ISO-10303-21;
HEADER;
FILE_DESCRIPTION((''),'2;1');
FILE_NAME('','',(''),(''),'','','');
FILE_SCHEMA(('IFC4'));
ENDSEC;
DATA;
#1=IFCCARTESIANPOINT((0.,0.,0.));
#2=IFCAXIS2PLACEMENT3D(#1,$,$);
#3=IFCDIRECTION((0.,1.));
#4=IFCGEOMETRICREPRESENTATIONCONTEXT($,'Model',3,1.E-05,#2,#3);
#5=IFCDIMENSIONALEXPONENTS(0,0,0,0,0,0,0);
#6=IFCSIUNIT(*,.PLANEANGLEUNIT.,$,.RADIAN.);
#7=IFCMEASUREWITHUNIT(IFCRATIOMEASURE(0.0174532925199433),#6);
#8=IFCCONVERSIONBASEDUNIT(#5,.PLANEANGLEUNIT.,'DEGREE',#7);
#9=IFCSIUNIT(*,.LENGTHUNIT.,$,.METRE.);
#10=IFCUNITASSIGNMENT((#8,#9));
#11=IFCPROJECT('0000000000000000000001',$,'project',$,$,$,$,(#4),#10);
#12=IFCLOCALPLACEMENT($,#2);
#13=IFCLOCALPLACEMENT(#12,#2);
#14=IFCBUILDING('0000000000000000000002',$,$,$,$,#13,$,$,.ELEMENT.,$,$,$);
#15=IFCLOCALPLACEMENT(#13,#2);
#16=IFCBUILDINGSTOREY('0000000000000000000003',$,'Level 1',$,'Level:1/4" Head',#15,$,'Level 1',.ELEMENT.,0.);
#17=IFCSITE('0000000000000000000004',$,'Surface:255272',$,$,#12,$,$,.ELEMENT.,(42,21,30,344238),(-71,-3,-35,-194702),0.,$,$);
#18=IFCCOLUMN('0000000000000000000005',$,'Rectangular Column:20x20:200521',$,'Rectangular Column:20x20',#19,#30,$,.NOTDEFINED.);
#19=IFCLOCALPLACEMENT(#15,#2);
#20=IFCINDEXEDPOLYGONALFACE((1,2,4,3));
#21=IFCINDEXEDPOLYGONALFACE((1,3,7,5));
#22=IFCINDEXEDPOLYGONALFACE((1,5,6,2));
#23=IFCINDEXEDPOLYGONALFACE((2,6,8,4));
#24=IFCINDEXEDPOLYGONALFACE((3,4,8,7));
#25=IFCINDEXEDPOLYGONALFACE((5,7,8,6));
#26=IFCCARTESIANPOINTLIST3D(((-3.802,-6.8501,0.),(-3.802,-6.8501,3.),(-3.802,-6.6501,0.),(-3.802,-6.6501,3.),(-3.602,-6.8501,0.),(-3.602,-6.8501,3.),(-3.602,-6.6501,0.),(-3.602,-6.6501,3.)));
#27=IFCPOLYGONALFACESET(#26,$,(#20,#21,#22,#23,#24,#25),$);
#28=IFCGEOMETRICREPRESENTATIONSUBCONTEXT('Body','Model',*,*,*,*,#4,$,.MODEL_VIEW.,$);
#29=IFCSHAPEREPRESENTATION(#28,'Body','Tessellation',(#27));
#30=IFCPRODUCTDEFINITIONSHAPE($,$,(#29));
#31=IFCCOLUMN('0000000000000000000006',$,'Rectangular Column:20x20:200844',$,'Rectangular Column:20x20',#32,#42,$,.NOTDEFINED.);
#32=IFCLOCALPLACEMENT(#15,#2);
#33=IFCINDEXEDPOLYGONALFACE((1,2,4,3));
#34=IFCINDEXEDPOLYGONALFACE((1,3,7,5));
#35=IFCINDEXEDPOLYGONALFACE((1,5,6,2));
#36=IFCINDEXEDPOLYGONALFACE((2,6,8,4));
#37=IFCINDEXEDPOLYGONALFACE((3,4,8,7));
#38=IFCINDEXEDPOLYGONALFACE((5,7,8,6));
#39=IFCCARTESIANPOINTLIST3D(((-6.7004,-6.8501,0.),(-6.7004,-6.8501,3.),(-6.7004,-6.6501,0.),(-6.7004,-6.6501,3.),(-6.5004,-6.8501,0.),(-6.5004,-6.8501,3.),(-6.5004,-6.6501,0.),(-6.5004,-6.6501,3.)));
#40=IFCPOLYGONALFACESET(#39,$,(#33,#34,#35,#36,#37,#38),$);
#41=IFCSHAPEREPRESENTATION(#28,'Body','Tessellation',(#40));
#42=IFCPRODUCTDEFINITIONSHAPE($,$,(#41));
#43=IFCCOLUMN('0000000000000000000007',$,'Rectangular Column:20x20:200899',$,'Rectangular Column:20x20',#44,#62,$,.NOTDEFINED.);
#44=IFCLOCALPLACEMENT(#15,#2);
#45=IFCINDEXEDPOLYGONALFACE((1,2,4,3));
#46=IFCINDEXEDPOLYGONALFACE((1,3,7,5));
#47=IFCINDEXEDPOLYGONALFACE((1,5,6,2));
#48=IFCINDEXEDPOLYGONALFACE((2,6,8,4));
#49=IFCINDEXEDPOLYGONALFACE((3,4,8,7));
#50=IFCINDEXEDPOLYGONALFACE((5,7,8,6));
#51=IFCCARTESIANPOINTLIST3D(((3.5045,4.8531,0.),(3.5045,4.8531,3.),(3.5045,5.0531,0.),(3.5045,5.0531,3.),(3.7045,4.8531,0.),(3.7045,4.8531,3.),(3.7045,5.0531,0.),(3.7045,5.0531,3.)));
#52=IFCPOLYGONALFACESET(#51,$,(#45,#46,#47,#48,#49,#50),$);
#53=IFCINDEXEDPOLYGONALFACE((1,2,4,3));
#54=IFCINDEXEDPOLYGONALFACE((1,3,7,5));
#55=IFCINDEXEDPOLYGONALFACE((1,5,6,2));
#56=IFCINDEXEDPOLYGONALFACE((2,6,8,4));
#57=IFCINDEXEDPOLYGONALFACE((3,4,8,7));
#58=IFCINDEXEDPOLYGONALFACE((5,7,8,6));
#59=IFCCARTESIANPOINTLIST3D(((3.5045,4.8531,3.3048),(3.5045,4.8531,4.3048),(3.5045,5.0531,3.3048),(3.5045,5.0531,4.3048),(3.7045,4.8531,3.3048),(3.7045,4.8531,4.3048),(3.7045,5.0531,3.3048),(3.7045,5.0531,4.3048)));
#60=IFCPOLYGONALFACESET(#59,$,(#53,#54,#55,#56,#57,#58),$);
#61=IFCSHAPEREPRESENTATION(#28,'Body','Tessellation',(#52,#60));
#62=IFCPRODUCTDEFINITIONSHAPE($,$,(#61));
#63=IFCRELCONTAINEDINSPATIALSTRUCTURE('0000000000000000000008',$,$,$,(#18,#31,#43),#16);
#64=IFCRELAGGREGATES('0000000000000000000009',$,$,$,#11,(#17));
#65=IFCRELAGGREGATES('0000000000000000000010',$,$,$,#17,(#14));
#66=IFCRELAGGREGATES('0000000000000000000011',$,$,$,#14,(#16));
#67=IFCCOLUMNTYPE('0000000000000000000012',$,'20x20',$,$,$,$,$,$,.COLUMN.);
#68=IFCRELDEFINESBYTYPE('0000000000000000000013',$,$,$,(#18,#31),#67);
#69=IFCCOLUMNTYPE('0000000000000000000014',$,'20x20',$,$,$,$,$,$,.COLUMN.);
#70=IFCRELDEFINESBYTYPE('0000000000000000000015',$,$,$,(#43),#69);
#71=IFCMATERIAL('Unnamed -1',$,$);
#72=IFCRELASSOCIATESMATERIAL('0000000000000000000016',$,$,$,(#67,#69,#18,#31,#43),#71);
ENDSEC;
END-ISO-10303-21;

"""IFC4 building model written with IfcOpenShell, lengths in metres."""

from ifc_helpers import new_model, entity, si_unit, converted_unit, direction, frame, frame_2d, origin, origin_2d_with_axis, place, context, subcontext, project, spatial, rectangle, extrude, source, transform, mapped, material, material_profile, profile_set, profile_usage, type_object, type_shapes, element, save


model = new_model("IFC4")

# Units and contexts
model_context = context("Model", 3, precision=1e-05, world=origin(), true_north=direction((0.0, 1.0)))
body_context = subcontext(model_context, "Body", "Model", "MODEL_VIEW")
ifc_project = project(units=[converted_unit("PLANEANGLEUNIT", "DEGREE", entity("IfcRatioMeasure", 0.0174532925199433), si_unit("PLANEANGLEUNIT", "RADIAN"), dimensions=[0, 0, 0, 0, 0, 0, 0]), si_unit("LENGTHUNIT", "METRE")], contexts=[model_context])

# Site, building, storey
site_placement = place(None, origin())
site = spatial("IfcSite", under=ifc_project, at=site_placement, Name="Surface:255272", CompositionType="ELEMENT", RefLatitude=(42, 21, 30, 344238), RefLongitude=(-71, -3, -35, -194702), RefElevation=0.0)
building_placement = place(site_placement, origin())
building = spatial("IfcBuilding", under=site, at=building_placement, CompositionType="ELEMENT")
storey_placement = place(building_placement, origin())
storey = spatial("IfcBuildingStorey", under=building, at=storey_placement, Name="Level 1", ObjectType="Level:1/4\" Head", LongName="Level 1", CompositionType="ELEMENT", Elevation=0.0)

# Columns
ifc_material_1 = material(Name="Unnamed -1")
ifc_material_profile_1 = material_profile(ifc_material_1, rectangle(XDim=0.2, YDim=0.2, at=origin_2d_with_axis()), Name="20x20")
ifc_profile_set_1 = profile_set([ifc_material_profile_1], Name="20x20")
ifc_profile_usage_1 = profile_usage(ifc_profile_set_1)
column_type_1 = type_object("IfcColumnType", Name="20x20", PredefinedType="COLUMN", material=ifc_profile_set_1)
shared_shape_1 = source(origin(), body_context, "Body", "SweptSolid", [
    extrude(rectangle(XDim=0.2, YDim=0.2, at=origin_2d_with_axis()), frame((0.0, 0.0, 0.0), z_axis=(0.0, 0.0, 1.0), x_axis=(0.0, -1.0, 0.0)), (0.0, 0.0, 1.0), 3.0),
])
type_shapes(column_type_1, [shared_shape_1])
column_1_placement = place(storey_placement, frame((-3.702, -6.7501, 0.0)))
element("IfcColumn", 1, at=column_1_placement, inside=storey, type_object=column_type_1, material=ifc_profile_usage_1, Name="Rectangular Column:20x20:200521", ObjectType="Rectangular Column:20x20", PredefinedType="NOTDEFINED", context=body_context, shape_type="MappedRepresentation", body=[
    mapped(shared_shape_1, transform((0.0, 0.0, 0.0), scale=1.0)),
])
ifc_profile_usage_2 = profile_usage(ifc_profile_set_1)
column_2_placement = place(storey_placement, frame((-6.6004, -6.7501, 0.0)))
element("IfcColumn", 2, at=column_2_placement, inside=storey, type_object=column_type_1, material=ifc_profile_usage_2, Name="Rectangular Column:20x20:200844", ObjectType="Rectangular Column:20x20", PredefinedType="NOTDEFINED", context=body_context, shape_type="MappedRepresentation", body=[
    mapped(shared_shape_1, transform((0.0, 0.0, 0.0), scale=1.0)),
])
ifc_profile_usage_3 = profile_usage(ifc_profile_set_1)
column_type_2 = type_object("IfcColumnType", Name="20x20", PredefinedType="COLUMN", material=ifc_profile_set_1)
shared_shape_2 = source(origin(), body_context, "Body", "SweptSolid", [
    extrude(rectangle(XDim=0.2, YDim=0.2, at=frame_2d((0.0, 0.0), x_axis=(1.0, 0.0))), frame((3.6045, 4.9531, 0.0), z_axis=(0.0, 0.0, 1.0), x_axis=(-1.0, 0.000007, 0.0)), (0.0, 0.0, 1.0), 3.0),
    extrude(rectangle(XDim=0.2, YDim=0.2, at=frame_2d((0.0, 0.0), x_axis=(1.0, 0.0))), frame((3.6045, 4.9531, 3.3048), z_axis=(0.0, 0.0, 1.0), x_axis=(-1.0, 0.000007, 0.0)), (0.0, 0.0, 1.0), 1.0),
])
type_shapes(column_type_2, [shared_shape_2])
column_3_placement = place(storey_placement, origin())
element("IfcColumn", 3, at=column_3_placement, inside=storey, type_object=column_type_2, material=ifc_profile_usage_3, Name="Rectangular Column:20x20:200899", ObjectType="Rectangular Column:20x20", PredefinedType="NOTDEFINED", context=body_context, shape_type="MappedRepresentation", body=[
    mapped(shared_shape_2, transform((0.0, 0.0, 0.0), scale=1.0)),
])

save(model, "model.ifc")
